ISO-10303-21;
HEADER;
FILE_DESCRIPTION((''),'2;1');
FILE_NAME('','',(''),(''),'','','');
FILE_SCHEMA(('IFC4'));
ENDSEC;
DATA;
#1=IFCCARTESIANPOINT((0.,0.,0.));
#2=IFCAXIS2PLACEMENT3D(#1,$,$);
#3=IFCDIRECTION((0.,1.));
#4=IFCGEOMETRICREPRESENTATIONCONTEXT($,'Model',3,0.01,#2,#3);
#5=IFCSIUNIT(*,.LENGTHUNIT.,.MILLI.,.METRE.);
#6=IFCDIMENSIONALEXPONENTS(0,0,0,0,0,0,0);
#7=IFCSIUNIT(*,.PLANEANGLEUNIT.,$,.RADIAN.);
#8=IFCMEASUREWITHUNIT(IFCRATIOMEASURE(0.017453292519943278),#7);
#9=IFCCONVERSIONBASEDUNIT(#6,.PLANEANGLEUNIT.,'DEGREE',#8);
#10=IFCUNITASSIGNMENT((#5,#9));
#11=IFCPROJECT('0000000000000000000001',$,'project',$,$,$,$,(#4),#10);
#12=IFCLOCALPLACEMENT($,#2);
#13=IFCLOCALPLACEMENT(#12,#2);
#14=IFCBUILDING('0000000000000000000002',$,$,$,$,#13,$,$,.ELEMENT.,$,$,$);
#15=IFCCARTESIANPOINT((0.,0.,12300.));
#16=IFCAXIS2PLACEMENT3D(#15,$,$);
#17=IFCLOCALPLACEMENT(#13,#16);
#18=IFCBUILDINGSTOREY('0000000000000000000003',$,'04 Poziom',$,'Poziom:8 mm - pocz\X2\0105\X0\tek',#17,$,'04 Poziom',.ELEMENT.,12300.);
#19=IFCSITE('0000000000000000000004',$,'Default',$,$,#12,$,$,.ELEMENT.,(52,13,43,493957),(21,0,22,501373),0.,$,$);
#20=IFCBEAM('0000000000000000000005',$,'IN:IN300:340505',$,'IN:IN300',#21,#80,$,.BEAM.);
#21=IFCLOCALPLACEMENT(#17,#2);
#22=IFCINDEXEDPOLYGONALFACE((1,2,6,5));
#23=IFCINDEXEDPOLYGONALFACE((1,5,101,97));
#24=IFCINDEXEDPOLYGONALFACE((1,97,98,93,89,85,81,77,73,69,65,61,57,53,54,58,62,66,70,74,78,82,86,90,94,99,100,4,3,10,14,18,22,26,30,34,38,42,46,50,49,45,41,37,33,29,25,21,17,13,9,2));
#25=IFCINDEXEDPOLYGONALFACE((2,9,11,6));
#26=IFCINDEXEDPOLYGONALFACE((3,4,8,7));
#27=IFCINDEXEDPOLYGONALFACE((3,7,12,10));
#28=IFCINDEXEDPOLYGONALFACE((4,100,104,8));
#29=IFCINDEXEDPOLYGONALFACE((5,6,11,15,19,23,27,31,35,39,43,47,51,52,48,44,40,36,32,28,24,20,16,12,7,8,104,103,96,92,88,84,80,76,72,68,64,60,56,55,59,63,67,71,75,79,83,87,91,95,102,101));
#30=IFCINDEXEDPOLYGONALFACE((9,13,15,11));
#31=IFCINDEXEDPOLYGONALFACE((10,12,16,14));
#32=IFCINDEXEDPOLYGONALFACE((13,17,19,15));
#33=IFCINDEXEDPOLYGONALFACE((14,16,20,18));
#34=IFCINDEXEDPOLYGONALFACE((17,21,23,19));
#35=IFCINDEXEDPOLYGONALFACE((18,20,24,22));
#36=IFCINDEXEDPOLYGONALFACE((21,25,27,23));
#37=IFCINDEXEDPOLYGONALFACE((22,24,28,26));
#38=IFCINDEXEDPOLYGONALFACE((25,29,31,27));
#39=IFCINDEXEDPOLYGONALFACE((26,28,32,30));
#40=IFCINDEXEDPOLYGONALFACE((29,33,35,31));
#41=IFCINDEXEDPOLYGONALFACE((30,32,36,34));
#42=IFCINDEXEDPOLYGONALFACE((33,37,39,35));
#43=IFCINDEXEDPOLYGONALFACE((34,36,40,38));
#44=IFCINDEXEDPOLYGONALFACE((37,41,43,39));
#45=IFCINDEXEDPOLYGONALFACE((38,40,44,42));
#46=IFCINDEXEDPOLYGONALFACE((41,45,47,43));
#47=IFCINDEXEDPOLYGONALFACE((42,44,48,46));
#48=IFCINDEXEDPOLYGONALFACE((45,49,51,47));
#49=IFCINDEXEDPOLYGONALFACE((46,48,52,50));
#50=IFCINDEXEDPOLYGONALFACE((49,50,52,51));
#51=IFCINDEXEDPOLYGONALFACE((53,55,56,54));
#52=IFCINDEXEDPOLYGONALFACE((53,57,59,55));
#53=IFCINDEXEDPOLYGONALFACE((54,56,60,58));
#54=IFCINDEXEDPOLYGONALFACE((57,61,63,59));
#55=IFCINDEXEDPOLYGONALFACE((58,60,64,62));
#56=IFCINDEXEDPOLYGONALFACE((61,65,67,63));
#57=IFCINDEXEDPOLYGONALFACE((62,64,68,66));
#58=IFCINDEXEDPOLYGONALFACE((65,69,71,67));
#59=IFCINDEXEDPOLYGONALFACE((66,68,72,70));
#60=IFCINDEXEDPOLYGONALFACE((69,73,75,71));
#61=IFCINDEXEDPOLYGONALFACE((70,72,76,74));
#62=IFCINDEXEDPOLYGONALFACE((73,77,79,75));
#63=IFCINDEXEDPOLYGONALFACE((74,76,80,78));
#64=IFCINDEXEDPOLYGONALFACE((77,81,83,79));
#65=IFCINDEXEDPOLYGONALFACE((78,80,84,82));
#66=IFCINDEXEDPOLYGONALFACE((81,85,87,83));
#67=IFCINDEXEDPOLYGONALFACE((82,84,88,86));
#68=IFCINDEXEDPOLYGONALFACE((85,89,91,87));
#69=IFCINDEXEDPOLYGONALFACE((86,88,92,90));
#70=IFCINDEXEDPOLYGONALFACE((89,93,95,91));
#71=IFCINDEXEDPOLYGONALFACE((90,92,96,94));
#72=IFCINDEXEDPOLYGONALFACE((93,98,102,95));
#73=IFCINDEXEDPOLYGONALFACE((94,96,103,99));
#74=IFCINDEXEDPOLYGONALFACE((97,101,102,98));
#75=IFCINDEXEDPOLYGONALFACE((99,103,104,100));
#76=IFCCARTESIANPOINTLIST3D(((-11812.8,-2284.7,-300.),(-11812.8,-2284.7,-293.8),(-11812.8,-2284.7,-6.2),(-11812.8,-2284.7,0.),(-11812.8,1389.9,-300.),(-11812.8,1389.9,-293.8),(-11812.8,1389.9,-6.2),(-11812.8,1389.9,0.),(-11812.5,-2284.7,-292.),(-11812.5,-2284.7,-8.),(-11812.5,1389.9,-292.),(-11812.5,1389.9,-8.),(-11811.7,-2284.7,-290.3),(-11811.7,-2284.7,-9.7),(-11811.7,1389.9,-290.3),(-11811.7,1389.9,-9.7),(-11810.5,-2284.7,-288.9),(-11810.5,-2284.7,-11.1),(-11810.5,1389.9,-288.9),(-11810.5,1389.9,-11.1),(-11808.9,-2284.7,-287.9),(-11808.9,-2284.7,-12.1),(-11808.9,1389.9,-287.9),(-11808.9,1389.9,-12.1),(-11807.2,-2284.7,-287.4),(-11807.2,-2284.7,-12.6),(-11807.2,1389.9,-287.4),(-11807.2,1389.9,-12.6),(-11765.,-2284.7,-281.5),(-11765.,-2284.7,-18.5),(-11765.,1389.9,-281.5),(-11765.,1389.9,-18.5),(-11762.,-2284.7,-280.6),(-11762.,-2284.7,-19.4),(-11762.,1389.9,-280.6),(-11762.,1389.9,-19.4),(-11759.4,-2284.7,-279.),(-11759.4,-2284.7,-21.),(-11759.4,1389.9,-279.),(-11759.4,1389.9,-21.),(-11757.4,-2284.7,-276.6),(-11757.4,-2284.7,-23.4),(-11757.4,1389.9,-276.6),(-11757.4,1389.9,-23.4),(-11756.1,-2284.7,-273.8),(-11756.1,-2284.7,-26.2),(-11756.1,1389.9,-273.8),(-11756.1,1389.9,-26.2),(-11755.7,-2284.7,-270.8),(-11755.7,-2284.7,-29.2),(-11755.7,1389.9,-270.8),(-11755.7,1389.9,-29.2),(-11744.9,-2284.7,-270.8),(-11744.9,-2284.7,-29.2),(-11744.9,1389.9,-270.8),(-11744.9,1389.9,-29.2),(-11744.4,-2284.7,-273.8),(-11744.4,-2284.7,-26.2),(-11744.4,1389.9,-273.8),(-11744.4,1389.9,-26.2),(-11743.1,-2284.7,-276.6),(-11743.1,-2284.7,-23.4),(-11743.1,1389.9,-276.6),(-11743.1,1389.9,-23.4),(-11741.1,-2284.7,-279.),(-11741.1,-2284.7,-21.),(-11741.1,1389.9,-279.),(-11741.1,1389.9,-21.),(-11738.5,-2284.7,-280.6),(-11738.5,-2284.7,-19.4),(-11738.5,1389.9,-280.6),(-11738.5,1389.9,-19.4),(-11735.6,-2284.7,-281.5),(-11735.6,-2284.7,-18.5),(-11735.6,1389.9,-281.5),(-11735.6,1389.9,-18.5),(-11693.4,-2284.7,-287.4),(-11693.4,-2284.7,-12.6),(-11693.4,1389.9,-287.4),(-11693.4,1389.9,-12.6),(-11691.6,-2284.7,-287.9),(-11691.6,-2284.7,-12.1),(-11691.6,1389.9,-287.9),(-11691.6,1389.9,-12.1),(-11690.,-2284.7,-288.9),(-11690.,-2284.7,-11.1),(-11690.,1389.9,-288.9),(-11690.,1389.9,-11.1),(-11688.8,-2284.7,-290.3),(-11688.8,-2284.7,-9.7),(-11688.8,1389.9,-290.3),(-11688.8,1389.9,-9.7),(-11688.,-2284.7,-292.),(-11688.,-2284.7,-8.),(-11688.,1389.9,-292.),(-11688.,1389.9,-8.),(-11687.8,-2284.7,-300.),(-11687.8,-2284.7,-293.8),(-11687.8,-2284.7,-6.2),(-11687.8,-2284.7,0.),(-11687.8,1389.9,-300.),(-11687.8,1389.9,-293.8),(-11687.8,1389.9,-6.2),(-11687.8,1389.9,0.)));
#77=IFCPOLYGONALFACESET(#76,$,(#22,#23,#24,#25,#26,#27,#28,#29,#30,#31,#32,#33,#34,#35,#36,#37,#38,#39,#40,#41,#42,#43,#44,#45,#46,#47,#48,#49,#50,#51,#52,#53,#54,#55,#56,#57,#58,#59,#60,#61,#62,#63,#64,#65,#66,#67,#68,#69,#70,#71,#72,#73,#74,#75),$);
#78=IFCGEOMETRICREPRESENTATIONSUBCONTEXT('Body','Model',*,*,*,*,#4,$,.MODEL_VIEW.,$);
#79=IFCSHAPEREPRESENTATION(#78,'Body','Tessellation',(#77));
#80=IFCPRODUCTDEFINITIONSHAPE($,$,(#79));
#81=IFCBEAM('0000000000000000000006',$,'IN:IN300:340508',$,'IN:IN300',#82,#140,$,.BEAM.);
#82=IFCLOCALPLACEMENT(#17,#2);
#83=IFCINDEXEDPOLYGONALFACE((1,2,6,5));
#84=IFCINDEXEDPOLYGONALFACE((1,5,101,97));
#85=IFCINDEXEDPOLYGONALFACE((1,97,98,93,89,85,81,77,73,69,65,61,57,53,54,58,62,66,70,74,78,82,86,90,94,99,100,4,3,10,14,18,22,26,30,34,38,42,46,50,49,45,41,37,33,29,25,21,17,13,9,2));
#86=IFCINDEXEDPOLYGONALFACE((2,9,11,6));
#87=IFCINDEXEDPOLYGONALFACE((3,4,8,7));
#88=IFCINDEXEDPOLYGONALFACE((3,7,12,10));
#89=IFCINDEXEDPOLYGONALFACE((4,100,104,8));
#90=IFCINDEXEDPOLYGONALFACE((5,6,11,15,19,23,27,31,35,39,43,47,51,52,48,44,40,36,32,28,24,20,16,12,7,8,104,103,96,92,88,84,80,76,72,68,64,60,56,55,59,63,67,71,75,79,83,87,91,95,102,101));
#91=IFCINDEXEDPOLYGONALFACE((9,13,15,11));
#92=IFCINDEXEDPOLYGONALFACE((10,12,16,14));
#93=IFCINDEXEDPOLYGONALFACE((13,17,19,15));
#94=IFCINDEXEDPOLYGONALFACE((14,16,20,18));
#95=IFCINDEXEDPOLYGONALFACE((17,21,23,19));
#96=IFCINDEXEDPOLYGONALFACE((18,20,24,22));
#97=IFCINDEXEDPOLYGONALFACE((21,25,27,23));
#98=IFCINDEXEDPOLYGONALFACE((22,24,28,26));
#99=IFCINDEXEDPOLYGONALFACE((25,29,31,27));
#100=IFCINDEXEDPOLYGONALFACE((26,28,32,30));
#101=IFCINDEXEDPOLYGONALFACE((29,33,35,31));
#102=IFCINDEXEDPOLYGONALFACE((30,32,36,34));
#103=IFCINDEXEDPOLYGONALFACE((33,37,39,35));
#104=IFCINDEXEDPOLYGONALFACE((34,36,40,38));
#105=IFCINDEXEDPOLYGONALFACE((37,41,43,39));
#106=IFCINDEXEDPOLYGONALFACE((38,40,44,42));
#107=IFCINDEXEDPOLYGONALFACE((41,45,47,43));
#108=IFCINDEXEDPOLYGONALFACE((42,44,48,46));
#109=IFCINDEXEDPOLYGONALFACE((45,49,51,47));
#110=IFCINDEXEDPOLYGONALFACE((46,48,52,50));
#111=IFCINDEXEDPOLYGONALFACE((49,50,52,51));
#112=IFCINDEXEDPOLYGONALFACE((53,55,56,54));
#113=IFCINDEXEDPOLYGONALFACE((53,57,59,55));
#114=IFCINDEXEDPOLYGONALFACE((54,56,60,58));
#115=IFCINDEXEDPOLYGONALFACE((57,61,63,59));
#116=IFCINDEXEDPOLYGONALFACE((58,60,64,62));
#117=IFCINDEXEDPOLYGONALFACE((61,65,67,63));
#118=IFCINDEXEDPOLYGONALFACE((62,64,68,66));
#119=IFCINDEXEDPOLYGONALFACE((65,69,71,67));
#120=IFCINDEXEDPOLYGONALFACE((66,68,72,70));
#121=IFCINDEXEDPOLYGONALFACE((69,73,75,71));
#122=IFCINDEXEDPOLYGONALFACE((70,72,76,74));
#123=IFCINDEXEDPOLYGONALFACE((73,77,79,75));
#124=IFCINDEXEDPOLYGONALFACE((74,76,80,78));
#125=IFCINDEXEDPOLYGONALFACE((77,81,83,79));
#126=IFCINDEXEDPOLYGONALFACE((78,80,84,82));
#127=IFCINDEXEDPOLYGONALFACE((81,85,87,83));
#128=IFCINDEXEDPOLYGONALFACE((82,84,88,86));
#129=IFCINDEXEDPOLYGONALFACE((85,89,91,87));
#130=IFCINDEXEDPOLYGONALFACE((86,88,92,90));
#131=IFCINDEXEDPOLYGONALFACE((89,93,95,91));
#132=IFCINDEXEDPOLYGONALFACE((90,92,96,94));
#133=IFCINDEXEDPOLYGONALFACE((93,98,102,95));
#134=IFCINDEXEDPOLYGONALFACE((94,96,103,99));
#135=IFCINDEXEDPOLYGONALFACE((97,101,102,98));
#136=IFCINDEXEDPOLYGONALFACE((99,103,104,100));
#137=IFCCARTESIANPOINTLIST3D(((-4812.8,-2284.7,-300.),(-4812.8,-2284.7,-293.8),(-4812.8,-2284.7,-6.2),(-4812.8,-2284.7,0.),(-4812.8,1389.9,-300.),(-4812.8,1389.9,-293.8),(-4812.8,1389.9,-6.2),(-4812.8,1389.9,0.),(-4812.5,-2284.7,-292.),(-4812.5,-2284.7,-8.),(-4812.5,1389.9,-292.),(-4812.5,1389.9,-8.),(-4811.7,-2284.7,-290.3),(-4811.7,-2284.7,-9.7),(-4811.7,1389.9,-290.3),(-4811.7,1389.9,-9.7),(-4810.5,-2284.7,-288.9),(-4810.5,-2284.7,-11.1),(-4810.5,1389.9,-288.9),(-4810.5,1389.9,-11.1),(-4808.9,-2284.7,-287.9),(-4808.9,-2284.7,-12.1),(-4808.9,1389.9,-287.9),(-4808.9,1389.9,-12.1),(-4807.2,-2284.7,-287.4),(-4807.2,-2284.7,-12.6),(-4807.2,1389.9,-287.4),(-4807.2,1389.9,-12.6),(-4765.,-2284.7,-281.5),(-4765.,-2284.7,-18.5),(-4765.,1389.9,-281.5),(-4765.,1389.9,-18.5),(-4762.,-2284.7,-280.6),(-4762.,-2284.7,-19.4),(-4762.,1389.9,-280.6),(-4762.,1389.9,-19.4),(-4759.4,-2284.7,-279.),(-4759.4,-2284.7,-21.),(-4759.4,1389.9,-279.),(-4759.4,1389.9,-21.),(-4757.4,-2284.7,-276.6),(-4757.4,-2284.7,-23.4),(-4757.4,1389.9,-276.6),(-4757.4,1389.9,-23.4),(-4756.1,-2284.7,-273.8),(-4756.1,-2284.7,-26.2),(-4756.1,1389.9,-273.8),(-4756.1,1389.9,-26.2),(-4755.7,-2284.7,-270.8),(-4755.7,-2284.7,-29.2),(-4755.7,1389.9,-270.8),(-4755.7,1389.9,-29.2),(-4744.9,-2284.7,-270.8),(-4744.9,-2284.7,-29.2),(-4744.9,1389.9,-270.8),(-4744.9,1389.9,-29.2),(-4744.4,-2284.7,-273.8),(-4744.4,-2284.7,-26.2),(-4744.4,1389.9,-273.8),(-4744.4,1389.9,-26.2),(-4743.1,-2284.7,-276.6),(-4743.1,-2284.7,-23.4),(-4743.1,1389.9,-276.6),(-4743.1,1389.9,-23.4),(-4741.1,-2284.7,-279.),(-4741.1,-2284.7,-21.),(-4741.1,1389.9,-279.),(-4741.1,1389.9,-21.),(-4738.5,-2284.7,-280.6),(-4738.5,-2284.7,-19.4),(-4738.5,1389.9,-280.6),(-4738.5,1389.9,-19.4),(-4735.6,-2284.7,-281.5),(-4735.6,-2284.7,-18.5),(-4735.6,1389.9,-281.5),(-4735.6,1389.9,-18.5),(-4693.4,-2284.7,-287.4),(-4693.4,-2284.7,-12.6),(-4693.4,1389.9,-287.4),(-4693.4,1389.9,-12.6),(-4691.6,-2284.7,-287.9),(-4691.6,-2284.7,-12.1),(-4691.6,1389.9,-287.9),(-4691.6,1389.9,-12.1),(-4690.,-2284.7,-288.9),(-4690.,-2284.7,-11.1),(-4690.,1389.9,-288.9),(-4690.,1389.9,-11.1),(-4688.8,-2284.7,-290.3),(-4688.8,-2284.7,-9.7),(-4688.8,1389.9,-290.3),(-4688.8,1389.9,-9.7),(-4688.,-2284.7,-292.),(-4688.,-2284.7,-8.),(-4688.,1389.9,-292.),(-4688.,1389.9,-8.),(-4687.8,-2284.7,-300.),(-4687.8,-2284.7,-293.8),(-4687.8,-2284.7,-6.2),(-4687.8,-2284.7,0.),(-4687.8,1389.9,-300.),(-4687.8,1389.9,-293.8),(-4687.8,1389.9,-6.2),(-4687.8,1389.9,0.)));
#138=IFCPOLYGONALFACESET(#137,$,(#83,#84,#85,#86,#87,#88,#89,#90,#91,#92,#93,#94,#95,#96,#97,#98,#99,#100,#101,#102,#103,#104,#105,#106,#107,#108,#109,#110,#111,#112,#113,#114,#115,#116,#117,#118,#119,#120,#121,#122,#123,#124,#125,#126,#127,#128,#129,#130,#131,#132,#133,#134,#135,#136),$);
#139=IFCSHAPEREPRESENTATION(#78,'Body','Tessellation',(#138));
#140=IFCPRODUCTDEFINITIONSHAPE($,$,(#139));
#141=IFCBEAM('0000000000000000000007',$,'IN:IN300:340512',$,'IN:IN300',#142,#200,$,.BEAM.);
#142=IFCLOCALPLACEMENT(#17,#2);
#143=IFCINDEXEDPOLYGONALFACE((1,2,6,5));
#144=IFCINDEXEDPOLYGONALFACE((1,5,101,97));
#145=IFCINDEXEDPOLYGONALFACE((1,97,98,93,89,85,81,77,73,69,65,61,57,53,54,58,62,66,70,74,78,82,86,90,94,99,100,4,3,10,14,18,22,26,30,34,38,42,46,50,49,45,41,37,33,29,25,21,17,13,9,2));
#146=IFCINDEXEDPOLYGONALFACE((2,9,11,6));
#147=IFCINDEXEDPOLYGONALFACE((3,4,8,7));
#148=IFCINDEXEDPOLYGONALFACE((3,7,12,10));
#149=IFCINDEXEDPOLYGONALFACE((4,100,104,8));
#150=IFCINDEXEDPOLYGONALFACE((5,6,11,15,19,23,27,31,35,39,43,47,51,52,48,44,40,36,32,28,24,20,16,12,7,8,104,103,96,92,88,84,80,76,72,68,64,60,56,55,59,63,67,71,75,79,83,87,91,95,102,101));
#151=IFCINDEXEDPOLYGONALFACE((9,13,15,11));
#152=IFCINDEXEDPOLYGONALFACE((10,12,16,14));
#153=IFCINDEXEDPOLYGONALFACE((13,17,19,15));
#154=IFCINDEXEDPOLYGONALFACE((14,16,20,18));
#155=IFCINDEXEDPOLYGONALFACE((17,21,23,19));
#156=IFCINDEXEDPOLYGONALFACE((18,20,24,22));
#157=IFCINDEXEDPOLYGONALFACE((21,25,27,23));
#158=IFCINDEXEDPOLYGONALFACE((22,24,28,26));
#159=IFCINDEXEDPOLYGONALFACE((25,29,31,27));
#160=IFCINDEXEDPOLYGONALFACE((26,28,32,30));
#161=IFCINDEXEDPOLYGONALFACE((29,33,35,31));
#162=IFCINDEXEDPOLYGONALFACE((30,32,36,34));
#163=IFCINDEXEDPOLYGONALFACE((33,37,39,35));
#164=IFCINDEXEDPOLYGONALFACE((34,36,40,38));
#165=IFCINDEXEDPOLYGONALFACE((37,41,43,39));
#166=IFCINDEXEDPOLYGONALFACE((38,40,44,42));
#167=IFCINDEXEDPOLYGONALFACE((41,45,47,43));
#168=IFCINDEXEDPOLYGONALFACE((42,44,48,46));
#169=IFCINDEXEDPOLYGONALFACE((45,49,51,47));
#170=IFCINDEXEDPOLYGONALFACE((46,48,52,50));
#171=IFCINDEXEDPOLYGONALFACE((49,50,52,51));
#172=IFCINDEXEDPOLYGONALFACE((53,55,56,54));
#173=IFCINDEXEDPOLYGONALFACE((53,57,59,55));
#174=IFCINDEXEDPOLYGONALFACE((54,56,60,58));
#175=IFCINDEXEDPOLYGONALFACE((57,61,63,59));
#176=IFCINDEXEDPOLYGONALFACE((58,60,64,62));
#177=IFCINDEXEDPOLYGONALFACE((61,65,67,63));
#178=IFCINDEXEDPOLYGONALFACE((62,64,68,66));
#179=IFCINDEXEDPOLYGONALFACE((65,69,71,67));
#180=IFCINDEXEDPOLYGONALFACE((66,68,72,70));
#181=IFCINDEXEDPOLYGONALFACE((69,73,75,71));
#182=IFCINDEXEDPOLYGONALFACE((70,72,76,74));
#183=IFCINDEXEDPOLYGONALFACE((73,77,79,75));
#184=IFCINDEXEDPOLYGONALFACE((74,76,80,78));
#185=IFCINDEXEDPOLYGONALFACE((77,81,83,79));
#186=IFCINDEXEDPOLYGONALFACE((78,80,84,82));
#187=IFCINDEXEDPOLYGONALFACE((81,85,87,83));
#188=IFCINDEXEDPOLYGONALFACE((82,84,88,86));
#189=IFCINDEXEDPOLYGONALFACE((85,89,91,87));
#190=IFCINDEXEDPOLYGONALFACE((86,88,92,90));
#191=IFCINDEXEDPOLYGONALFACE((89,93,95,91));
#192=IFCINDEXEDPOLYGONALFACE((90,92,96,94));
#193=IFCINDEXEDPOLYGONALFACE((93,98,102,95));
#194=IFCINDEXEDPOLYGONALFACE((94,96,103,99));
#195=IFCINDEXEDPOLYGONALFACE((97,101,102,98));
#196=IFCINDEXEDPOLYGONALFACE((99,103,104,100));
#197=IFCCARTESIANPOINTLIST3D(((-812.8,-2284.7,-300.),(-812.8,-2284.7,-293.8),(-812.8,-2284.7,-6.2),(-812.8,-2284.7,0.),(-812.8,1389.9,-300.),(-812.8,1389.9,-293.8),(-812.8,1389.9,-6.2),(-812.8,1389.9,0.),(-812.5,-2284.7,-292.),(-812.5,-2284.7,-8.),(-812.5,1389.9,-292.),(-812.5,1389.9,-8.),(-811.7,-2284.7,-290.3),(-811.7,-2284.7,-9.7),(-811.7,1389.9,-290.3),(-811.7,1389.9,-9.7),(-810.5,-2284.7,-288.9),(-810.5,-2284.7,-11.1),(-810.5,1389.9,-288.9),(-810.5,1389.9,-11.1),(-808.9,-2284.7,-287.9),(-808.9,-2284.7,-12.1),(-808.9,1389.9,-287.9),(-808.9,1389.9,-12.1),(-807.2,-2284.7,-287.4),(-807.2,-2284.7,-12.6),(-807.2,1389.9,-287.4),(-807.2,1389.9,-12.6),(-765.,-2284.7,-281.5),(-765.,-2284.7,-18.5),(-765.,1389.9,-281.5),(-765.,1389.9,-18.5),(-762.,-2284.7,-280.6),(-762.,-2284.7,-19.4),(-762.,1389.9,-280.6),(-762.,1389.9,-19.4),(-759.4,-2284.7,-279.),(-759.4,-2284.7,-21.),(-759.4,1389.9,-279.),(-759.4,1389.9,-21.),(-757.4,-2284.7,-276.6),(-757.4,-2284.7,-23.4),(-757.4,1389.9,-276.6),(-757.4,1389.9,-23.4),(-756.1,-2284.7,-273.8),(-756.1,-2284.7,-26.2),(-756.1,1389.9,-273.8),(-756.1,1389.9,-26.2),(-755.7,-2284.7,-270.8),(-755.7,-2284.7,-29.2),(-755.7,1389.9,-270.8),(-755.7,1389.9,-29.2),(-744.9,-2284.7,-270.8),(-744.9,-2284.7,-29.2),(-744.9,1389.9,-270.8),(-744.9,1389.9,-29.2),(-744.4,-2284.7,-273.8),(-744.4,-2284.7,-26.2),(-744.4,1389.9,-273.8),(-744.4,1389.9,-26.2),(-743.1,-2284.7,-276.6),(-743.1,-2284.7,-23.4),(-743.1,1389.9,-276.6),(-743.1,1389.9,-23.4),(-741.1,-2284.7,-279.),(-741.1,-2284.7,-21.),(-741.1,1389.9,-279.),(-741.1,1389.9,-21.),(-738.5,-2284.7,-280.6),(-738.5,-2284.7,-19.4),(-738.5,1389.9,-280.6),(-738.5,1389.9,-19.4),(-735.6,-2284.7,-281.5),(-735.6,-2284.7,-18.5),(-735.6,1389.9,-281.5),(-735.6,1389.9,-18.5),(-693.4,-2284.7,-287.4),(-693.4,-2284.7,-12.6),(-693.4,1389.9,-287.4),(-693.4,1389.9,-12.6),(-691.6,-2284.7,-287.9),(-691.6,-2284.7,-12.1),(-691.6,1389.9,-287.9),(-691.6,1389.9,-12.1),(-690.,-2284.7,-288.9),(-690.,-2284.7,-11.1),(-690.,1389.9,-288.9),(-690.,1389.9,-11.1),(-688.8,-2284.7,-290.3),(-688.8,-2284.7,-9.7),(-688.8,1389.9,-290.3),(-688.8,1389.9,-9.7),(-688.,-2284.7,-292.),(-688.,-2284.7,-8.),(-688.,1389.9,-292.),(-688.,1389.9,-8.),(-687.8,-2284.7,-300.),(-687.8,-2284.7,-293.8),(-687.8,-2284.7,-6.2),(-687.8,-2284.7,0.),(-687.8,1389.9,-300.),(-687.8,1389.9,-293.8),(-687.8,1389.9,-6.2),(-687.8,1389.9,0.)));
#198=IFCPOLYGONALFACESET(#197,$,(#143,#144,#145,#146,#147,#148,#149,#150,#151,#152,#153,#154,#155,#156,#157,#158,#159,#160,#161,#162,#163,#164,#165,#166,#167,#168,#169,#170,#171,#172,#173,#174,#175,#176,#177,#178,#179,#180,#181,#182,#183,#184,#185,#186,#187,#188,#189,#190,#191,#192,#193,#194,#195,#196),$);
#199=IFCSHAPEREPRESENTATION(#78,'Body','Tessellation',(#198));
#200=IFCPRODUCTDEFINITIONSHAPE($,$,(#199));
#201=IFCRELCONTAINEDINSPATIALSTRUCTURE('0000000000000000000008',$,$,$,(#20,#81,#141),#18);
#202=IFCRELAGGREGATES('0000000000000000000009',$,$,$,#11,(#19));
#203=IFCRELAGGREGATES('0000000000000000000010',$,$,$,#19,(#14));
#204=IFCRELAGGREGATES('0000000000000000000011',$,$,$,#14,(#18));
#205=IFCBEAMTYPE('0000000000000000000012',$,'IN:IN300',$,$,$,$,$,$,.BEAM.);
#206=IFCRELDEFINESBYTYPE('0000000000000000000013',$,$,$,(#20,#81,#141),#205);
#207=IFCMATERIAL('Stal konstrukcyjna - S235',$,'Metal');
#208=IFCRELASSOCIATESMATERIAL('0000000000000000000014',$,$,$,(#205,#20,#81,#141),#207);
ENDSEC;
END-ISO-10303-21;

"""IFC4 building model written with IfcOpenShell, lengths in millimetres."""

from ifc_helpers import new_model, entity, si_unit, converted_unit, direction, frame, origin, place, context, subcontext, project, spatial, line, arc, indexed_curve, outline, extrude, source, transform, mapped, material, type_object, type_shapes, element, save


model = new_model("IFC4")

# Units and contexts
model_context = context("Model", 3, precision=0.01, world=origin(), true_north=direction((0.0, 1.0)))
body_context = subcontext(model_context, "Body", "Model", "MODEL_VIEW")
ifc_project = project(units=[si_unit("LENGTHUNIT", "METRE", prefix="MILLI"), converted_unit("PLANEANGLEUNIT", "DEGREE", entity("IfcRatioMeasure", 0.017453292519943278), si_unit("PLANEANGLEUNIT", "RADIAN"), dimensions=[0, 0, 0, 0, 0, 0, 0])], contexts=[model_context])

# Site, building, storey
site_placement = place(None, origin())
site = spatial("IfcSite", under=ifc_project, at=site_placement, Name="Default", CompositionType="ELEMENT", RefLatitude=(52, 13, 43, 493957), RefLongitude=(21, 0, 22, 501373), RefElevation=0.0)
building_placement = place(site_placement, origin())
building = spatial("IfcBuilding", under=site, at=building_placement, CompositionType="ELEMENT")
storey_placement = place(building_placement, frame((0.0, 0.0, 12300.0)))
storey = spatial("IfcBuildingStorey", under=building, at=storey_placement, Name="04 Poziom", ObjectType="Poziom:8 mm - początek", LongName="04 Poziom", CompositionType="ELEMENT", Elevation=12300.0)

# Shared definitions
ifc_material_1 = material(Name="Stal konstrukcyjna - S235", Category="Metal")

# Beams
beam_type_1 = type_object("IfcBeamType", Name="IN:IN300", PredefinedType="BEAM", material=ifc_material_1)
shared_shape_1 = source(origin(), body_context, "Body", "SweptSolid", [
    extrude(outline(indexed_curve([(143.8, -62.5), (150.0, -62.5), (150.0, 62.5), (143.8, 62.5), (139.6, 60.9), (137.4, 56.9), (131.5, 14.7), (127.9, 8.1), (120.8, 5.4), (-120.8, 5.4), (-127.9, 8.1), (-131.5, 14.7), (-137.4, 56.9), (-139.6, 60.9), (-143.8, 62.5), (-150.0, 62.5), (-150.0, -62.5), (-143.8, -62.5), (-139.6, -60.9), (-137.4, -56.9), (-131.5, -14.7), (-127.9, -8.1), (-120.8, -5.4), (120.8, -5.4), (127.9, -8.1), (131.5, -14.7), (137.4, -56.9), (139.6, -60.9)], segments=[line(1, 2, 3, 4), arc(4, 5, 6), line(6, 7), arc(7, 8, 9), line(9, 10), arc(10, 11, 12), line(12, 13), arc(13, 14, 15), line(15, 16, 17, 18), arc(18, 19, 20), line(20, 21), arc(21, 22, 23), line(23, 24), arc(24, 25, 26), line(26, 27), arc(27, 28, 1)], self_intersect=False)), frame((-1837.3, 0.0, 0.0), z_axis=(1.0, 0.0, 0.0), x_axis=(0.0, 0.0, -1.0)), (0.0, 0.0, 1.0), 3674.6),
])
type_shapes(beam_type_1, [shared_shape_1])
for number, where, z_axis, x_axis, name in (
    (1, (-11750.3, -447.4, -150.0), (0.0, 0.0, 1.0), (0.0, -1.0, 0.0), "IN:IN300:340505"),
    (2, (-4750.3, -447.4, -150.0), (0.0, 0.0, 1.0), (0.0, -1.0, 0.0), "IN:IN300:340508"),
    (3, (-750.3, -447.4, -150.0), (0.0, 0.0, 1.0), (0.0, -1.0, 0.0), "IN:IN300:340512"),
):
    element("IfcBeam", number, at=place(storey_placement, frame(where, z_axis=z_axis, x_axis=x_axis)), inside=storey, type_object=beam_type_1, material=ifc_material_1, Name=name, ObjectType="IN:IN300", PredefinedType="BEAM", context=body_context, shape_type="MappedRepresentation", body=[
        mapped(shared_shape_1, transform((0.0, 0.0, 0.0), scale=1.0)),
    ])

save(model, "model.ifc")
